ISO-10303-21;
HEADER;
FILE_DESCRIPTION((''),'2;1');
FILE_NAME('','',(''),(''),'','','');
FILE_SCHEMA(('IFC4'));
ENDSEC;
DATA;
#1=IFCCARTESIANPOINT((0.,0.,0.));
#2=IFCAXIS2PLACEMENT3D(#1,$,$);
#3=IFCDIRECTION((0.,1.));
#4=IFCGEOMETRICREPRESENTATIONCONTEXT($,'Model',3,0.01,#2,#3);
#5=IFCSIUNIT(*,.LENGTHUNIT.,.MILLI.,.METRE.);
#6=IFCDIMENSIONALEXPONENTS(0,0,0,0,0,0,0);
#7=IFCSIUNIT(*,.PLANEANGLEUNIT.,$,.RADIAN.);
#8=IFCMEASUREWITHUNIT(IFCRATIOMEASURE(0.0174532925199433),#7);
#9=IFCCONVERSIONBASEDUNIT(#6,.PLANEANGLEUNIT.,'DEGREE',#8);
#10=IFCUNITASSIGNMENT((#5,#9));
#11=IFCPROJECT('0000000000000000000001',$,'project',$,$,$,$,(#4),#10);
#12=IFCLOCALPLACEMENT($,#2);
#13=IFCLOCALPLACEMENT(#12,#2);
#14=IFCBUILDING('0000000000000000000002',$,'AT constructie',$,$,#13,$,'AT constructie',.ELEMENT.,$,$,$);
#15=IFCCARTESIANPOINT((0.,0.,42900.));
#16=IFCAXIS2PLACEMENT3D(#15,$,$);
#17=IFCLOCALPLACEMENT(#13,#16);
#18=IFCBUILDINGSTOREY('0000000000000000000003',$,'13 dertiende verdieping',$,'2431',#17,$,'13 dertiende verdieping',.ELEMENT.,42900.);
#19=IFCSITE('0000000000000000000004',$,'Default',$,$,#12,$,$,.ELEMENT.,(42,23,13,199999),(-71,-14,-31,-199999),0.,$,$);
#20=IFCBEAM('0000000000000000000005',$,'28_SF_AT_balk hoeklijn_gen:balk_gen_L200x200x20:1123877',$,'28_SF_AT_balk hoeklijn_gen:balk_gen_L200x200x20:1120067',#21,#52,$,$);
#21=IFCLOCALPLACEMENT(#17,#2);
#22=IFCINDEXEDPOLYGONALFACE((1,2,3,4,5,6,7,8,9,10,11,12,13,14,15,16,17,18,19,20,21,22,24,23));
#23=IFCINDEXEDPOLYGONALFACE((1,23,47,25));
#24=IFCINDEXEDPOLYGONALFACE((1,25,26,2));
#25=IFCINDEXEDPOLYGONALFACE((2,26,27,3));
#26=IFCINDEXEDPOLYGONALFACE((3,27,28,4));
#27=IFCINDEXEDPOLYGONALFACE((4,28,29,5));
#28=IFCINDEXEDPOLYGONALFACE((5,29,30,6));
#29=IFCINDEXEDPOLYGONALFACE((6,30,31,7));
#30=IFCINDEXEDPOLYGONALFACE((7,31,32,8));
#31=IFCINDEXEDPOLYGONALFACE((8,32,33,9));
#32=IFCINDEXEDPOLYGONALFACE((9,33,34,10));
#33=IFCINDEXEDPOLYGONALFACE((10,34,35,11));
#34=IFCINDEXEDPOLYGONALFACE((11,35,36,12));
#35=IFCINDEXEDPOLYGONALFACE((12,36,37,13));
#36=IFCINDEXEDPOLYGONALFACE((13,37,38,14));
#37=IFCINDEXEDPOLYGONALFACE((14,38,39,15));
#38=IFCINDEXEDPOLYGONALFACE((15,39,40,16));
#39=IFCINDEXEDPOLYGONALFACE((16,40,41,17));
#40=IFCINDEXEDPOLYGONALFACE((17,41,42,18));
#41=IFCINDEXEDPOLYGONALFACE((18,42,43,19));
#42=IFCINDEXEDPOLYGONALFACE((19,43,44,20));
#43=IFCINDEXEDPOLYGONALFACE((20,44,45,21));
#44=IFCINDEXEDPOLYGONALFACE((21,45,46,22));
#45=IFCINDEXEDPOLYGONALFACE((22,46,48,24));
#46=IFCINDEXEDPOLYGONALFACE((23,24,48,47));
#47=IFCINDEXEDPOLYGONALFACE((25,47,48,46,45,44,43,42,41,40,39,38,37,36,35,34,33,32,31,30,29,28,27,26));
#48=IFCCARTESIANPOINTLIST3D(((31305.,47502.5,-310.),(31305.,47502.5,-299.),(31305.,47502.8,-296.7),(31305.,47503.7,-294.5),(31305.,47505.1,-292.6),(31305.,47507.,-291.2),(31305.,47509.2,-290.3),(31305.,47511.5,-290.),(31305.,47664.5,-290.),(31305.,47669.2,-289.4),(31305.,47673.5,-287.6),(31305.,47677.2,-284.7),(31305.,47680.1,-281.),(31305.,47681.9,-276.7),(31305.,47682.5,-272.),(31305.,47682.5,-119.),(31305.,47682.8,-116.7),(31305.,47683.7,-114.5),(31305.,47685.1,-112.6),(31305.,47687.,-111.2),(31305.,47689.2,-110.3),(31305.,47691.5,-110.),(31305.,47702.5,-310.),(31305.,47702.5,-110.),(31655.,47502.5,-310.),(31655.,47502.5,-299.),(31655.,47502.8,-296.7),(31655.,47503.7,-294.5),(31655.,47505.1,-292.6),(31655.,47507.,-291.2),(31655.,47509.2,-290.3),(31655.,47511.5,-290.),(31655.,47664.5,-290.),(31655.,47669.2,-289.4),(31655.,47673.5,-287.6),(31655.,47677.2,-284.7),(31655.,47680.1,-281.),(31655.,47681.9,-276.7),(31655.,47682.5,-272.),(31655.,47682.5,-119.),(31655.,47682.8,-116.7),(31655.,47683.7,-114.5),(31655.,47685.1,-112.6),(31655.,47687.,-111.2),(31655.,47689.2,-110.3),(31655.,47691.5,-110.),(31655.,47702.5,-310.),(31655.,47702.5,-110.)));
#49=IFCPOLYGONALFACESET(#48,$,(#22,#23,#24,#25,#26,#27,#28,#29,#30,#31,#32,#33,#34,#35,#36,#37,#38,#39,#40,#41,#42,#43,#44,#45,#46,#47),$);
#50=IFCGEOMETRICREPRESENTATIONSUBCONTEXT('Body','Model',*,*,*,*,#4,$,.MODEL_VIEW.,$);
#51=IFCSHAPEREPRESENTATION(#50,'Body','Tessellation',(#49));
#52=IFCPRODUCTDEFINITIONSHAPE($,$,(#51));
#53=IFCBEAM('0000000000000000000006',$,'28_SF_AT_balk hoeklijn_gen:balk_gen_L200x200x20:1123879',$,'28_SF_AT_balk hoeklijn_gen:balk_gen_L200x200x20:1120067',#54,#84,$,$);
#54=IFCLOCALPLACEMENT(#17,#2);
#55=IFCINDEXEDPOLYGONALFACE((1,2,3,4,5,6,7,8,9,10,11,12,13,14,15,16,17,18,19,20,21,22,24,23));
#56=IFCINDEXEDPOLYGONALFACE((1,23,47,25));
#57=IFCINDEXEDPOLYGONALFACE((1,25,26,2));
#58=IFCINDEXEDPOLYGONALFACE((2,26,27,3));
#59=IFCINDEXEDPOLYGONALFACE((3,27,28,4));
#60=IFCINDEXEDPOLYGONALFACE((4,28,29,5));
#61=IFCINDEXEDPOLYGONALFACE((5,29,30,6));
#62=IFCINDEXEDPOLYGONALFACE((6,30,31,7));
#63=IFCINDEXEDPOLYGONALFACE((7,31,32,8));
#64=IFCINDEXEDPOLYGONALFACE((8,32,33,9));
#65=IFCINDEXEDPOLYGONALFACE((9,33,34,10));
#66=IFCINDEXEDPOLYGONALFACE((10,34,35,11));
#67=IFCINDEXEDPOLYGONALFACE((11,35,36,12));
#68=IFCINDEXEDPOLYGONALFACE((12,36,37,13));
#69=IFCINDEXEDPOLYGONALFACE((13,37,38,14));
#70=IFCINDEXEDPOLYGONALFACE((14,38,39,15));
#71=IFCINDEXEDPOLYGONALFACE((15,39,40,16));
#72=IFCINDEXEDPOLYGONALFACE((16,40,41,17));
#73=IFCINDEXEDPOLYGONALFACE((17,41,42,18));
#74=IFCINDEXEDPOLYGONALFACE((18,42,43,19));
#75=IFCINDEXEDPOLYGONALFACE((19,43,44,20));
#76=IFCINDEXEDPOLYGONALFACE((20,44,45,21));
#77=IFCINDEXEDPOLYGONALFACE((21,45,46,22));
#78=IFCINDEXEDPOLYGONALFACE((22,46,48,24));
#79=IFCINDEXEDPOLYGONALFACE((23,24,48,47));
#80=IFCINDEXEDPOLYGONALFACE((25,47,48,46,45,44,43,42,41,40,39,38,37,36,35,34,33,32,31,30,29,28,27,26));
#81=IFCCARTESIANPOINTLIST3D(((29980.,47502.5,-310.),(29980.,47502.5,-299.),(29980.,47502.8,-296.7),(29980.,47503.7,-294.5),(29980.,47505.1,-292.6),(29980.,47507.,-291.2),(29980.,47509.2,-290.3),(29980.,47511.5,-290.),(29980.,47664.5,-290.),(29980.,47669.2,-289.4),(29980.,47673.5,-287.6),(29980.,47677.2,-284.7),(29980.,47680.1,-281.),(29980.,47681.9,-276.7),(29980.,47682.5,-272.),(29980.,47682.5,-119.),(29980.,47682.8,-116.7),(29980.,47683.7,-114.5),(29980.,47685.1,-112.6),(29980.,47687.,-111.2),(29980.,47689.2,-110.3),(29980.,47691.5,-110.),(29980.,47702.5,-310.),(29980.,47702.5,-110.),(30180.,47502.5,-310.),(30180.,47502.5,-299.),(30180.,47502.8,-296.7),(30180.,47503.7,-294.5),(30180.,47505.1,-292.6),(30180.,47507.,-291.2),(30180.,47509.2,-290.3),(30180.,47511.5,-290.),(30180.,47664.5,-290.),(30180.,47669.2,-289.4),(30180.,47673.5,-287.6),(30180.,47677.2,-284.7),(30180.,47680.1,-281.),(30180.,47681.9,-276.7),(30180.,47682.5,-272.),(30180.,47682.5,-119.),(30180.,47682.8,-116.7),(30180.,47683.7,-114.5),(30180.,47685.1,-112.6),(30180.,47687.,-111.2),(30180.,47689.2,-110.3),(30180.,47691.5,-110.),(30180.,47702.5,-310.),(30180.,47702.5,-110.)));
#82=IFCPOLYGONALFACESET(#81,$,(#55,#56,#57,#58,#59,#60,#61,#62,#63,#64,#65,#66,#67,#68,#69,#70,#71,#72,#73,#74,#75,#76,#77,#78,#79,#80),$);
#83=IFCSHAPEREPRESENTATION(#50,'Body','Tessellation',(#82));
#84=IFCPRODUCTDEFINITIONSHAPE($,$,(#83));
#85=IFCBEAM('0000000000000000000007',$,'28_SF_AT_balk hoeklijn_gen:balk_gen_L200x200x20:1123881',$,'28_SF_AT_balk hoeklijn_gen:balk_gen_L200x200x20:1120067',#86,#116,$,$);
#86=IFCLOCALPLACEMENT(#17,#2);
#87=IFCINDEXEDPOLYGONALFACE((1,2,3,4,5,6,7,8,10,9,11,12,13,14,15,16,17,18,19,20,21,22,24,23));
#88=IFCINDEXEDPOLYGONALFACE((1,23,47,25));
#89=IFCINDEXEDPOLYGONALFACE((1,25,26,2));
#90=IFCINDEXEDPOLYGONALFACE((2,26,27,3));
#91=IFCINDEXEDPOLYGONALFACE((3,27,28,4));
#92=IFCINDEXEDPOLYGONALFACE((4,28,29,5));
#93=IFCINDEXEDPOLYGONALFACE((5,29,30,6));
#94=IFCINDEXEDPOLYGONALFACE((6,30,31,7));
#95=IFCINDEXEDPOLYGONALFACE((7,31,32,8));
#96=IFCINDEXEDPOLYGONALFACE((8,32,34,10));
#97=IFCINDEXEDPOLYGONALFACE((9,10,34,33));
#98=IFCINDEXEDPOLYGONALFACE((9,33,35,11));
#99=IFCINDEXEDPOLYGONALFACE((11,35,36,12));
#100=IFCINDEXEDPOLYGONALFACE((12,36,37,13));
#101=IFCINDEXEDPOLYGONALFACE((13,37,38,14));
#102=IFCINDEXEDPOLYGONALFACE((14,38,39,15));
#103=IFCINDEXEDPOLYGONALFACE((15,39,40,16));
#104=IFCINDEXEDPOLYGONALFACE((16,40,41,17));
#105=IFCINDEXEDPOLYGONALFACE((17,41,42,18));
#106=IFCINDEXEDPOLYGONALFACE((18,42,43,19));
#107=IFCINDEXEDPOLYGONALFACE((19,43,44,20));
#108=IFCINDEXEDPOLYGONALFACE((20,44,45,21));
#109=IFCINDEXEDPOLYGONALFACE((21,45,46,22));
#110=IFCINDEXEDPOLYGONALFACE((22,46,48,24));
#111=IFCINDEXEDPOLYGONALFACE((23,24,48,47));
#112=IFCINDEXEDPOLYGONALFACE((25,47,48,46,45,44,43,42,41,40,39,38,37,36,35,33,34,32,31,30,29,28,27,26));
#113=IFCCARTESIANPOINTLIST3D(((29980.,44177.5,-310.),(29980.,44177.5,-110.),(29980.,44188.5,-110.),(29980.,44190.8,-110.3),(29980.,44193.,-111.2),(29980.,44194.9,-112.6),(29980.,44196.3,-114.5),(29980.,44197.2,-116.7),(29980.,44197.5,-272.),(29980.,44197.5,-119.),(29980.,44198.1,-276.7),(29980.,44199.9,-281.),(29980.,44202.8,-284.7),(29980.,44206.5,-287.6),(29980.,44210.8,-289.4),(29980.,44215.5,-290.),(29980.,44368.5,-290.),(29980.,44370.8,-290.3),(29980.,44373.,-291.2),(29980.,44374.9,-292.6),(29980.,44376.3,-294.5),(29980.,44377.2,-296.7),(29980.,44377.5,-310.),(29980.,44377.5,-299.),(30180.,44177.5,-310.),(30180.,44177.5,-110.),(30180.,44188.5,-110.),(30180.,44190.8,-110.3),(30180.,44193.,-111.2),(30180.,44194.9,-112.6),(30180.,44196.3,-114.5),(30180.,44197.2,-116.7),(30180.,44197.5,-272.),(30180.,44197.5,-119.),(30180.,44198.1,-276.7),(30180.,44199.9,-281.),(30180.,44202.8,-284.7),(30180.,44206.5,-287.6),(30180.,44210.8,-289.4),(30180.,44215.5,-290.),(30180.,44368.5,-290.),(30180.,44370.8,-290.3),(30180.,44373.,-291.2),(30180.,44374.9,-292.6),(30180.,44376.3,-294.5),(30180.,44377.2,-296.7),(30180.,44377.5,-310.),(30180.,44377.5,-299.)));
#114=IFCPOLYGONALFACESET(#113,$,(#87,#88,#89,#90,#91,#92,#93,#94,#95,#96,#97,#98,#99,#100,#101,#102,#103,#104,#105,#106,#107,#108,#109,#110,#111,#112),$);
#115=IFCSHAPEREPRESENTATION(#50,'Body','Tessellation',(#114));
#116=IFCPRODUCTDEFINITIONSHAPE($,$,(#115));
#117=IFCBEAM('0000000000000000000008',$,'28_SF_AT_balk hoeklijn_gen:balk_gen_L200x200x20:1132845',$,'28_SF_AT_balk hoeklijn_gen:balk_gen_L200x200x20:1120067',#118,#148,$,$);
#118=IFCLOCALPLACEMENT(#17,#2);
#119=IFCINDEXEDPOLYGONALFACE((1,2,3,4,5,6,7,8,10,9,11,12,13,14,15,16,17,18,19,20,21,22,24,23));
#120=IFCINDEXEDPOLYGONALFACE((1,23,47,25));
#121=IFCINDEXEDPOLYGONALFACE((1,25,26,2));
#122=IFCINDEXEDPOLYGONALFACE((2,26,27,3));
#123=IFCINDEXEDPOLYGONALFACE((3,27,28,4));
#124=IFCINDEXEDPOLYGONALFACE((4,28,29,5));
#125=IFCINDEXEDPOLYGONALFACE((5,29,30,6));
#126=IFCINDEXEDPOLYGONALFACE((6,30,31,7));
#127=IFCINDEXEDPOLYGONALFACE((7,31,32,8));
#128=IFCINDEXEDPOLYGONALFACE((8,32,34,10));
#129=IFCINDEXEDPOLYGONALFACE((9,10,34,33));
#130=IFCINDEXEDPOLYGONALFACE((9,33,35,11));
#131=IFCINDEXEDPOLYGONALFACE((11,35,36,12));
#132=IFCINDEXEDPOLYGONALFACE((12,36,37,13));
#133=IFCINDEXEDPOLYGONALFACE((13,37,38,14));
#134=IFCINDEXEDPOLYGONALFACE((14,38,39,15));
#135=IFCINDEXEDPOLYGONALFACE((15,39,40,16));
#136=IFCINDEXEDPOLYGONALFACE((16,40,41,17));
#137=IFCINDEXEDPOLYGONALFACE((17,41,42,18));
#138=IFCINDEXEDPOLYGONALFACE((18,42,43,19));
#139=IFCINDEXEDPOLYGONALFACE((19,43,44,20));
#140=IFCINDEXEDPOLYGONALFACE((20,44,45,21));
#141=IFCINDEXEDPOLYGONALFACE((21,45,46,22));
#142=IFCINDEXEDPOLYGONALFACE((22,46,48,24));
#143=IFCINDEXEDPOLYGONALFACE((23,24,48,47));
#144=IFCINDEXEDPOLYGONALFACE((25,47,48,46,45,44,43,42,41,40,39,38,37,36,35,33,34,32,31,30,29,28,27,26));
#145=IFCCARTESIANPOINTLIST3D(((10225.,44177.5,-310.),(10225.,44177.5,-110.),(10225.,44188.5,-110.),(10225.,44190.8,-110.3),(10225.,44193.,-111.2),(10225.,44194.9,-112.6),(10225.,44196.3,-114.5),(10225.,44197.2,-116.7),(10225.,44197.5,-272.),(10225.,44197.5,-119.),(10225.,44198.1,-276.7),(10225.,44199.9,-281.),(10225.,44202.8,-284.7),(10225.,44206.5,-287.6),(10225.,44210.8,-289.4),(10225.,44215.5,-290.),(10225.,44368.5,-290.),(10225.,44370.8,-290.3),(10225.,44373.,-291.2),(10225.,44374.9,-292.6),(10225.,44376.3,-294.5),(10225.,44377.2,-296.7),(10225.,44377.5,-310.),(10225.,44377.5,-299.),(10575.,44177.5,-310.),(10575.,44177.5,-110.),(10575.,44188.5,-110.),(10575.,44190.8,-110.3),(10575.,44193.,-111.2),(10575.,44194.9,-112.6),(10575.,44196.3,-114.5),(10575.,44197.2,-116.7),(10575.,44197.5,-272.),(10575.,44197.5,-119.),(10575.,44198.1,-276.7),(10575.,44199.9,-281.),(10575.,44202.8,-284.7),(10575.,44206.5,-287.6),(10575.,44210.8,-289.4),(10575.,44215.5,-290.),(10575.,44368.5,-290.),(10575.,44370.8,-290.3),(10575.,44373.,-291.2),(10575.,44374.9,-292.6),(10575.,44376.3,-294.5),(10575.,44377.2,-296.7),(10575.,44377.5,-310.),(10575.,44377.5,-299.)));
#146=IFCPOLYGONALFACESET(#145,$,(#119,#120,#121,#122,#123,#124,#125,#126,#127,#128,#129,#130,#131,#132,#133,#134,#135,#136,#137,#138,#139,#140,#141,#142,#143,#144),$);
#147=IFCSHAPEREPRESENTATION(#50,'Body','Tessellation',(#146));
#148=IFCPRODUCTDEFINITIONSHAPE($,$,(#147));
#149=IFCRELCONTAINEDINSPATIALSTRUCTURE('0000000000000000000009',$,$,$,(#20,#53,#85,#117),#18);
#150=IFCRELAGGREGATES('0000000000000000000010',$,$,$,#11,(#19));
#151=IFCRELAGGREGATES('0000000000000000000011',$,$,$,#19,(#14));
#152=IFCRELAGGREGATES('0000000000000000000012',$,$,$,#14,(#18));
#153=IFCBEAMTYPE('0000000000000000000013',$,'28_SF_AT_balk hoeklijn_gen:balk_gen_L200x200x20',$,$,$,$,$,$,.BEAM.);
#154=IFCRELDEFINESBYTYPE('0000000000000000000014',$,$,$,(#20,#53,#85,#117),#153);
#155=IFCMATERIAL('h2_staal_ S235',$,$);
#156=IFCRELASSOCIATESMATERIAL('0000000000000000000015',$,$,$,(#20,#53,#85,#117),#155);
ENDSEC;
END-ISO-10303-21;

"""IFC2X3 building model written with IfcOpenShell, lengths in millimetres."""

from ifc_helpers import new_model, entity, si_unit, converted_unit, direction, frame, frame_2d, origin, place, context, subcontext, project, spatial, polyline, circle_curve, parameter, trimmed, segment, composite_curve, outline, extrude, material, type_object, element, save


model = new_model("IFC2X3")

# Units and contexts
model_context = context("Model", 3, precision=0.01, world=origin(), true_north=direction((0.0, 1.0)))
body_context = subcontext(model_context, "Body", "Model", "MODEL_VIEW")
ifc_project = project(units=[si_unit("LENGTHUNIT", "METRE", prefix="MILLI"), converted_unit("PLANEANGLEUNIT", "DEGREE", entity("IfcRatioMeasure", 0.0174532925199433), si_unit("PLANEANGLEUNIT", "RADIAN"), dimensions=[0, 0, 0, 0, 0, 0, 0])], contexts=[model_context])

# Site, building, storey
site_placement = place(None, origin())
site = spatial("IfcSite", under=ifc_project, at=site_placement, Name="Default", CompositionType="ELEMENT", RefLatitude=(42, 23, 13, 199999), RefLongitude=(-71, -14, -31, -199999), RefElevation=0.0)
building_placement = place(site_placement, origin())
building = spatial("IfcBuilding", under=site, at=building_placement, Name="AT constructie", LongName="AT constructie", CompositionType="ELEMENT")
storey_placement = place(building_placement, frame((0.0, 0.0, 42900.0)))
storey = spatial("IfcBuildingStorey", under=building, at=storey_placement, Name="13 dertiende verdieping", ObjectType="2431", LongName="13 dertiende verdieping", CompositionType="ELEMENT", Elevation=42900.0)

# Beams
ifc_material_1 = material(Name="h2_staal_ S235")
beam_type_1 = type_object("IfcBeamType", Name="28_SF_AT_balk hoeklijn_gen:balk_gen_L200x200x20", PredefinedType="BEAM")
beam_1_placement = place(storey_placement, frame((31655.0, 47702.5, -70.0), z_axis=(0.0, 0.0, 1.0), x_axis=(-1.0, 0.0, 0.0)))
element("IfcBeam", 1, at=beam_1_placement, inside=storey, type_object=beam_type_1, material=ifc_material_1, Name="28_SF_AT_balk hoeklijn_gen:balk_gen_L200x200x20:1123877", ObjectType="28_SF_AT_balk hoeklijn_gen:balk_gen_L200x200x20:1120067", context=body_context, shape_type="SweptSolid", body=[
    extrude(outline(composite_curve([segment(polyline([(-124.4, -75.6), (75.6, -75.6)]), True, "CONTINUOUS"), segment(polyline([(75.6, -75.6), (75.6, 124.4)]), True, "CONTINUOUS"), segment(polyline([(75.6, 124.4), (64.6, 124.4)]), True, "CONTINUOUS"), segment(trimmed(circle_curve(frame_2d((64.6, 115.4), x_axis=(0.0, 1.0)), 9.0), [parameter(0.0)], [parameter(90.0)], True, "PARAMETER"), True, "CONTINUOUS"), segment(polyline([(55.6, 115.4), (55.6, -37.6)]), True, "CONTINUOUS"), segment(trimmed(circle_curve(frame_2d((37.6, -37.6), x_axis=(1.0, 0.0)), 18.0), [parameter(270.0)], [parameter(0.0)], True, "PARAMETER"), False, "CONTINUOUS"), segment(polyline([(37.6, -55.6), (-115.4, -55.6)]), True, "CONTINUOUS"), segment(trimmed(circle_curve(frame_2d((-115.4, -64.6), x_axis=(0.0, 1.0)), 9.0), [parameter(0.0)], [parameter(90.0)], True, "PARAMETER"), True, "CONTINUOUS"), segment(polyline([(-124.4, -64.6), (-124.4, -75.6)]), True, "CONTINUOUS")], self_intersect=False)), frame((0.0, 75.6, -164.4), z_axis=(1.0, 0.0, 0.0), x_axis=(0.0, 0.0, -1.0)), (0.0, 0.0, 1.0), 350.0),
])
beam_2_placement = place(storey_placement, frame((30180.0, 47702.5, -70.0), z_axis=(0.0, 0.0, 1.0), x_axis=(-1.0, 0.0, 0.0)))
element("IfcBeam", 2, at=beam_2_placement, inside=storey, type_object=beam_type_1, material=ifc_material_1, Name="28_SF_AT_balk hoeklijn_gen:balk_gen_L200x200x20:1123879", ObjectType="28_SF_AT_balk hoeklijn_gen:balk_gen_L200x200x20:1120067", context=body_context, shape_type="SweptSolid", body=[
    extrude(outline(composite_curve([segment(polyline([(-124.4, -75.6), (75.6, -75.6)]), True, "CONTINUOUS"), segment(polyline([(75.6, -75.6), (75.6, 124.4)]), True, "CONTINUOUS"), segment(polyline([(75.6, 124.4), (64.6, 124.4)]), True, "CONTINUOUS"), segment(trimmed(circle_curve(frame_2d((64.6, 115.4), x_axis=(0.0, 1.0)), 9.0), [parameter(0.0)], [parameter(90.0)], True, "PARAMETER"), True, "CONTINUOUS"), segment(polyline([(55.6, 115.4), (55.6, -37.6)]), True, "CONTINUOUS"), segment(trimmed(circle_curve(frame_2d((37.6, -37.6), x_axis=(1.0, 0.0)), 18.0), [parameter(270.0)], [parameter(0.0)], True, "PARAMETER"), False, "CONTINUOUS"), segment(polyline([(37.6, -55.6), (-115.4, -55.6)]), True, "CONTINUOUS"), segment(trimmed(circle_curve(frame_2d((-115.4, -64.6), x_axis=(0.0, 1.0)), 9.0), [parameter(0.0)], [parameter(90.0)], True, "PARAMETER"), True, "CONTINUOUS"), segment(polyline([(-124.4, -64.6), (-124.4, -75.6)]), True, "CONTINUOUS")], self_intersect=False)), frame((0.0, 75.6, -164.4), z_axis=(1.0, 0.0, 0.0), x_axis=(0.0, 0.0, -1.0)), (0.0, 0.0, 1.0), 200.0),
])
beam_3_placement = place(storey_placement, frame((29980.0, 44177.5, -70.0)))
element("IfcBeam", 3, at=beam_3_placement, inside=storey, type_object=beam_type_1, material=ifc_material_1, Name="28_SF_AT_balk hoeklijn_gen:balk_gen_L200x200x20:1123881", ObjectType="28_SF_AT_balk hoeklijn_gen:balk_gen_L200x200x20:1120067", context=body_context, shape_type="SweptSolid", body=[
    extrude(outline(composite_curve([segment(polyline([(-124.4, -75.6), (75.6, -75.6)]), True, "CONTINUOUS"), segment(polyline([(75.6, -75.6), (75.6, 124.4)]), True, "CONTINUOUS"), segment(polyline([(75.6, 124.4), (64.6, 124.4)]), True, "CONTINUOUS"), segment(trimmed(circle_curve(frame_2d((64.6, 115.4), x_axis=(0.0, 1.0)), 9.0), [parameter(0.0)], [parameter(90.0)], True, "PARAMETER"), True, "CONTINUOUS"), segment(polyline([(55.6, 115.4), (55.6, -37.6)]), True, "CONTINUOUS"), segment(trimmed(circle_curve(frame_2d((37.6, -37.6), x_axis=(1.0, 0.0)), 18.0), [parameter(270.0)], [parameter(0.0)], True, "PARAMETER"), False, "CONTINUOUS"), segment(polyline([(37.6, -55.6), (-115.4, -55.6)]), True, "CONTINUOUS"), segment(trimmed(circle_curve(frame_2d((-115.4, -64.6), x_axis=(0.0, 1.0)), 9.0), [parameter(0.0)], [parameter(90.0)], True, "PARAMETER"), True, "CONTINUOUS"), segment(polyline([(-124.4, -64.6), (-124.4, -75.6)]), True, "CONTINUOUS")], self_intersect=False)), frame((0.0, 75.6, -164.4), z_axis=(1.0, 0.0, 0.0), x_axis=(0.0, 0.0, -1.0)), (0.0, 0.0, 1.0), 200.0),
])
beam_4_placement = place(storey_placement, frame((10225.0, 44177.5, -70.0)))
element("IfcBeam", 4, at=beam_4_placement, inside=storey, type_object=beam_type_1, material=ifc_material_1, Name="28_SF_AT_balk hoeklijn_gen:balk_gen_L200x200x20:1132845", ObjectType="28_SF_AT_balk hoeklijn_gen:balk_gen_L200x200x20:1120067", context=body_context, shape_type="SweptSolid", body=[
    extrude(outline(composite_curve([segment(polyline([(-124.4, -75.6), (75.6, -75.6)]), True, "CONTINUOUS"), segment(polyline([(75.6, -75.6), (75.6, 124.4)]), True, "CONTINUOUS"), segment(polyline([(75.6, 124.4), (64.6, 124.4)]), True, "CONTINUOUS"), segment(trimmed(circle_curve(frame_2d((64.6, 115.4), x_axis=(0.0, 1.0)), 9.0), [parameter(0.0)], [parameter(90.0)], True, "PARAMETER"), True, "CONTINUOUS"), segment(polyline([(55.6, 115.4), (55.6, -37.6)]), True, "CONTINUOUS"), segment(trimmed(circle_curve(frame_2d((37.6, -37.6), x_axis=(1.0, 0.0)), 18.0), [parameter(270.0)], [parameter(0.0)], True, "PARAMETER"), False, "CONTINUOUS"), segment(polyline([(37.6, -55.6), (-115.4, -55.6)]), True, "CONTINUOUS"), segment(trimmed(circle_curve(frame_2d((-115.4, -64.6), x_axis=(0.0, 1.0)), 9.0), [parameter(0.0)], [parameter(90.0)], True, "PARAMETER"), True, "CONTINUOUS"), segment(polyline([(-124.4, -64.6), (-124.4, -75.6)]), True, "CONTINUOUS")], self_intersect=False)), frame((0.0, 75.6, -164.4), z_axis=(1.0, 0.0, 0.0), x_axis=(0.0, 0.0, -1.0)), (0.0, 0.0, 1.0), 350.0),
])

save(model, "model.ifc")
